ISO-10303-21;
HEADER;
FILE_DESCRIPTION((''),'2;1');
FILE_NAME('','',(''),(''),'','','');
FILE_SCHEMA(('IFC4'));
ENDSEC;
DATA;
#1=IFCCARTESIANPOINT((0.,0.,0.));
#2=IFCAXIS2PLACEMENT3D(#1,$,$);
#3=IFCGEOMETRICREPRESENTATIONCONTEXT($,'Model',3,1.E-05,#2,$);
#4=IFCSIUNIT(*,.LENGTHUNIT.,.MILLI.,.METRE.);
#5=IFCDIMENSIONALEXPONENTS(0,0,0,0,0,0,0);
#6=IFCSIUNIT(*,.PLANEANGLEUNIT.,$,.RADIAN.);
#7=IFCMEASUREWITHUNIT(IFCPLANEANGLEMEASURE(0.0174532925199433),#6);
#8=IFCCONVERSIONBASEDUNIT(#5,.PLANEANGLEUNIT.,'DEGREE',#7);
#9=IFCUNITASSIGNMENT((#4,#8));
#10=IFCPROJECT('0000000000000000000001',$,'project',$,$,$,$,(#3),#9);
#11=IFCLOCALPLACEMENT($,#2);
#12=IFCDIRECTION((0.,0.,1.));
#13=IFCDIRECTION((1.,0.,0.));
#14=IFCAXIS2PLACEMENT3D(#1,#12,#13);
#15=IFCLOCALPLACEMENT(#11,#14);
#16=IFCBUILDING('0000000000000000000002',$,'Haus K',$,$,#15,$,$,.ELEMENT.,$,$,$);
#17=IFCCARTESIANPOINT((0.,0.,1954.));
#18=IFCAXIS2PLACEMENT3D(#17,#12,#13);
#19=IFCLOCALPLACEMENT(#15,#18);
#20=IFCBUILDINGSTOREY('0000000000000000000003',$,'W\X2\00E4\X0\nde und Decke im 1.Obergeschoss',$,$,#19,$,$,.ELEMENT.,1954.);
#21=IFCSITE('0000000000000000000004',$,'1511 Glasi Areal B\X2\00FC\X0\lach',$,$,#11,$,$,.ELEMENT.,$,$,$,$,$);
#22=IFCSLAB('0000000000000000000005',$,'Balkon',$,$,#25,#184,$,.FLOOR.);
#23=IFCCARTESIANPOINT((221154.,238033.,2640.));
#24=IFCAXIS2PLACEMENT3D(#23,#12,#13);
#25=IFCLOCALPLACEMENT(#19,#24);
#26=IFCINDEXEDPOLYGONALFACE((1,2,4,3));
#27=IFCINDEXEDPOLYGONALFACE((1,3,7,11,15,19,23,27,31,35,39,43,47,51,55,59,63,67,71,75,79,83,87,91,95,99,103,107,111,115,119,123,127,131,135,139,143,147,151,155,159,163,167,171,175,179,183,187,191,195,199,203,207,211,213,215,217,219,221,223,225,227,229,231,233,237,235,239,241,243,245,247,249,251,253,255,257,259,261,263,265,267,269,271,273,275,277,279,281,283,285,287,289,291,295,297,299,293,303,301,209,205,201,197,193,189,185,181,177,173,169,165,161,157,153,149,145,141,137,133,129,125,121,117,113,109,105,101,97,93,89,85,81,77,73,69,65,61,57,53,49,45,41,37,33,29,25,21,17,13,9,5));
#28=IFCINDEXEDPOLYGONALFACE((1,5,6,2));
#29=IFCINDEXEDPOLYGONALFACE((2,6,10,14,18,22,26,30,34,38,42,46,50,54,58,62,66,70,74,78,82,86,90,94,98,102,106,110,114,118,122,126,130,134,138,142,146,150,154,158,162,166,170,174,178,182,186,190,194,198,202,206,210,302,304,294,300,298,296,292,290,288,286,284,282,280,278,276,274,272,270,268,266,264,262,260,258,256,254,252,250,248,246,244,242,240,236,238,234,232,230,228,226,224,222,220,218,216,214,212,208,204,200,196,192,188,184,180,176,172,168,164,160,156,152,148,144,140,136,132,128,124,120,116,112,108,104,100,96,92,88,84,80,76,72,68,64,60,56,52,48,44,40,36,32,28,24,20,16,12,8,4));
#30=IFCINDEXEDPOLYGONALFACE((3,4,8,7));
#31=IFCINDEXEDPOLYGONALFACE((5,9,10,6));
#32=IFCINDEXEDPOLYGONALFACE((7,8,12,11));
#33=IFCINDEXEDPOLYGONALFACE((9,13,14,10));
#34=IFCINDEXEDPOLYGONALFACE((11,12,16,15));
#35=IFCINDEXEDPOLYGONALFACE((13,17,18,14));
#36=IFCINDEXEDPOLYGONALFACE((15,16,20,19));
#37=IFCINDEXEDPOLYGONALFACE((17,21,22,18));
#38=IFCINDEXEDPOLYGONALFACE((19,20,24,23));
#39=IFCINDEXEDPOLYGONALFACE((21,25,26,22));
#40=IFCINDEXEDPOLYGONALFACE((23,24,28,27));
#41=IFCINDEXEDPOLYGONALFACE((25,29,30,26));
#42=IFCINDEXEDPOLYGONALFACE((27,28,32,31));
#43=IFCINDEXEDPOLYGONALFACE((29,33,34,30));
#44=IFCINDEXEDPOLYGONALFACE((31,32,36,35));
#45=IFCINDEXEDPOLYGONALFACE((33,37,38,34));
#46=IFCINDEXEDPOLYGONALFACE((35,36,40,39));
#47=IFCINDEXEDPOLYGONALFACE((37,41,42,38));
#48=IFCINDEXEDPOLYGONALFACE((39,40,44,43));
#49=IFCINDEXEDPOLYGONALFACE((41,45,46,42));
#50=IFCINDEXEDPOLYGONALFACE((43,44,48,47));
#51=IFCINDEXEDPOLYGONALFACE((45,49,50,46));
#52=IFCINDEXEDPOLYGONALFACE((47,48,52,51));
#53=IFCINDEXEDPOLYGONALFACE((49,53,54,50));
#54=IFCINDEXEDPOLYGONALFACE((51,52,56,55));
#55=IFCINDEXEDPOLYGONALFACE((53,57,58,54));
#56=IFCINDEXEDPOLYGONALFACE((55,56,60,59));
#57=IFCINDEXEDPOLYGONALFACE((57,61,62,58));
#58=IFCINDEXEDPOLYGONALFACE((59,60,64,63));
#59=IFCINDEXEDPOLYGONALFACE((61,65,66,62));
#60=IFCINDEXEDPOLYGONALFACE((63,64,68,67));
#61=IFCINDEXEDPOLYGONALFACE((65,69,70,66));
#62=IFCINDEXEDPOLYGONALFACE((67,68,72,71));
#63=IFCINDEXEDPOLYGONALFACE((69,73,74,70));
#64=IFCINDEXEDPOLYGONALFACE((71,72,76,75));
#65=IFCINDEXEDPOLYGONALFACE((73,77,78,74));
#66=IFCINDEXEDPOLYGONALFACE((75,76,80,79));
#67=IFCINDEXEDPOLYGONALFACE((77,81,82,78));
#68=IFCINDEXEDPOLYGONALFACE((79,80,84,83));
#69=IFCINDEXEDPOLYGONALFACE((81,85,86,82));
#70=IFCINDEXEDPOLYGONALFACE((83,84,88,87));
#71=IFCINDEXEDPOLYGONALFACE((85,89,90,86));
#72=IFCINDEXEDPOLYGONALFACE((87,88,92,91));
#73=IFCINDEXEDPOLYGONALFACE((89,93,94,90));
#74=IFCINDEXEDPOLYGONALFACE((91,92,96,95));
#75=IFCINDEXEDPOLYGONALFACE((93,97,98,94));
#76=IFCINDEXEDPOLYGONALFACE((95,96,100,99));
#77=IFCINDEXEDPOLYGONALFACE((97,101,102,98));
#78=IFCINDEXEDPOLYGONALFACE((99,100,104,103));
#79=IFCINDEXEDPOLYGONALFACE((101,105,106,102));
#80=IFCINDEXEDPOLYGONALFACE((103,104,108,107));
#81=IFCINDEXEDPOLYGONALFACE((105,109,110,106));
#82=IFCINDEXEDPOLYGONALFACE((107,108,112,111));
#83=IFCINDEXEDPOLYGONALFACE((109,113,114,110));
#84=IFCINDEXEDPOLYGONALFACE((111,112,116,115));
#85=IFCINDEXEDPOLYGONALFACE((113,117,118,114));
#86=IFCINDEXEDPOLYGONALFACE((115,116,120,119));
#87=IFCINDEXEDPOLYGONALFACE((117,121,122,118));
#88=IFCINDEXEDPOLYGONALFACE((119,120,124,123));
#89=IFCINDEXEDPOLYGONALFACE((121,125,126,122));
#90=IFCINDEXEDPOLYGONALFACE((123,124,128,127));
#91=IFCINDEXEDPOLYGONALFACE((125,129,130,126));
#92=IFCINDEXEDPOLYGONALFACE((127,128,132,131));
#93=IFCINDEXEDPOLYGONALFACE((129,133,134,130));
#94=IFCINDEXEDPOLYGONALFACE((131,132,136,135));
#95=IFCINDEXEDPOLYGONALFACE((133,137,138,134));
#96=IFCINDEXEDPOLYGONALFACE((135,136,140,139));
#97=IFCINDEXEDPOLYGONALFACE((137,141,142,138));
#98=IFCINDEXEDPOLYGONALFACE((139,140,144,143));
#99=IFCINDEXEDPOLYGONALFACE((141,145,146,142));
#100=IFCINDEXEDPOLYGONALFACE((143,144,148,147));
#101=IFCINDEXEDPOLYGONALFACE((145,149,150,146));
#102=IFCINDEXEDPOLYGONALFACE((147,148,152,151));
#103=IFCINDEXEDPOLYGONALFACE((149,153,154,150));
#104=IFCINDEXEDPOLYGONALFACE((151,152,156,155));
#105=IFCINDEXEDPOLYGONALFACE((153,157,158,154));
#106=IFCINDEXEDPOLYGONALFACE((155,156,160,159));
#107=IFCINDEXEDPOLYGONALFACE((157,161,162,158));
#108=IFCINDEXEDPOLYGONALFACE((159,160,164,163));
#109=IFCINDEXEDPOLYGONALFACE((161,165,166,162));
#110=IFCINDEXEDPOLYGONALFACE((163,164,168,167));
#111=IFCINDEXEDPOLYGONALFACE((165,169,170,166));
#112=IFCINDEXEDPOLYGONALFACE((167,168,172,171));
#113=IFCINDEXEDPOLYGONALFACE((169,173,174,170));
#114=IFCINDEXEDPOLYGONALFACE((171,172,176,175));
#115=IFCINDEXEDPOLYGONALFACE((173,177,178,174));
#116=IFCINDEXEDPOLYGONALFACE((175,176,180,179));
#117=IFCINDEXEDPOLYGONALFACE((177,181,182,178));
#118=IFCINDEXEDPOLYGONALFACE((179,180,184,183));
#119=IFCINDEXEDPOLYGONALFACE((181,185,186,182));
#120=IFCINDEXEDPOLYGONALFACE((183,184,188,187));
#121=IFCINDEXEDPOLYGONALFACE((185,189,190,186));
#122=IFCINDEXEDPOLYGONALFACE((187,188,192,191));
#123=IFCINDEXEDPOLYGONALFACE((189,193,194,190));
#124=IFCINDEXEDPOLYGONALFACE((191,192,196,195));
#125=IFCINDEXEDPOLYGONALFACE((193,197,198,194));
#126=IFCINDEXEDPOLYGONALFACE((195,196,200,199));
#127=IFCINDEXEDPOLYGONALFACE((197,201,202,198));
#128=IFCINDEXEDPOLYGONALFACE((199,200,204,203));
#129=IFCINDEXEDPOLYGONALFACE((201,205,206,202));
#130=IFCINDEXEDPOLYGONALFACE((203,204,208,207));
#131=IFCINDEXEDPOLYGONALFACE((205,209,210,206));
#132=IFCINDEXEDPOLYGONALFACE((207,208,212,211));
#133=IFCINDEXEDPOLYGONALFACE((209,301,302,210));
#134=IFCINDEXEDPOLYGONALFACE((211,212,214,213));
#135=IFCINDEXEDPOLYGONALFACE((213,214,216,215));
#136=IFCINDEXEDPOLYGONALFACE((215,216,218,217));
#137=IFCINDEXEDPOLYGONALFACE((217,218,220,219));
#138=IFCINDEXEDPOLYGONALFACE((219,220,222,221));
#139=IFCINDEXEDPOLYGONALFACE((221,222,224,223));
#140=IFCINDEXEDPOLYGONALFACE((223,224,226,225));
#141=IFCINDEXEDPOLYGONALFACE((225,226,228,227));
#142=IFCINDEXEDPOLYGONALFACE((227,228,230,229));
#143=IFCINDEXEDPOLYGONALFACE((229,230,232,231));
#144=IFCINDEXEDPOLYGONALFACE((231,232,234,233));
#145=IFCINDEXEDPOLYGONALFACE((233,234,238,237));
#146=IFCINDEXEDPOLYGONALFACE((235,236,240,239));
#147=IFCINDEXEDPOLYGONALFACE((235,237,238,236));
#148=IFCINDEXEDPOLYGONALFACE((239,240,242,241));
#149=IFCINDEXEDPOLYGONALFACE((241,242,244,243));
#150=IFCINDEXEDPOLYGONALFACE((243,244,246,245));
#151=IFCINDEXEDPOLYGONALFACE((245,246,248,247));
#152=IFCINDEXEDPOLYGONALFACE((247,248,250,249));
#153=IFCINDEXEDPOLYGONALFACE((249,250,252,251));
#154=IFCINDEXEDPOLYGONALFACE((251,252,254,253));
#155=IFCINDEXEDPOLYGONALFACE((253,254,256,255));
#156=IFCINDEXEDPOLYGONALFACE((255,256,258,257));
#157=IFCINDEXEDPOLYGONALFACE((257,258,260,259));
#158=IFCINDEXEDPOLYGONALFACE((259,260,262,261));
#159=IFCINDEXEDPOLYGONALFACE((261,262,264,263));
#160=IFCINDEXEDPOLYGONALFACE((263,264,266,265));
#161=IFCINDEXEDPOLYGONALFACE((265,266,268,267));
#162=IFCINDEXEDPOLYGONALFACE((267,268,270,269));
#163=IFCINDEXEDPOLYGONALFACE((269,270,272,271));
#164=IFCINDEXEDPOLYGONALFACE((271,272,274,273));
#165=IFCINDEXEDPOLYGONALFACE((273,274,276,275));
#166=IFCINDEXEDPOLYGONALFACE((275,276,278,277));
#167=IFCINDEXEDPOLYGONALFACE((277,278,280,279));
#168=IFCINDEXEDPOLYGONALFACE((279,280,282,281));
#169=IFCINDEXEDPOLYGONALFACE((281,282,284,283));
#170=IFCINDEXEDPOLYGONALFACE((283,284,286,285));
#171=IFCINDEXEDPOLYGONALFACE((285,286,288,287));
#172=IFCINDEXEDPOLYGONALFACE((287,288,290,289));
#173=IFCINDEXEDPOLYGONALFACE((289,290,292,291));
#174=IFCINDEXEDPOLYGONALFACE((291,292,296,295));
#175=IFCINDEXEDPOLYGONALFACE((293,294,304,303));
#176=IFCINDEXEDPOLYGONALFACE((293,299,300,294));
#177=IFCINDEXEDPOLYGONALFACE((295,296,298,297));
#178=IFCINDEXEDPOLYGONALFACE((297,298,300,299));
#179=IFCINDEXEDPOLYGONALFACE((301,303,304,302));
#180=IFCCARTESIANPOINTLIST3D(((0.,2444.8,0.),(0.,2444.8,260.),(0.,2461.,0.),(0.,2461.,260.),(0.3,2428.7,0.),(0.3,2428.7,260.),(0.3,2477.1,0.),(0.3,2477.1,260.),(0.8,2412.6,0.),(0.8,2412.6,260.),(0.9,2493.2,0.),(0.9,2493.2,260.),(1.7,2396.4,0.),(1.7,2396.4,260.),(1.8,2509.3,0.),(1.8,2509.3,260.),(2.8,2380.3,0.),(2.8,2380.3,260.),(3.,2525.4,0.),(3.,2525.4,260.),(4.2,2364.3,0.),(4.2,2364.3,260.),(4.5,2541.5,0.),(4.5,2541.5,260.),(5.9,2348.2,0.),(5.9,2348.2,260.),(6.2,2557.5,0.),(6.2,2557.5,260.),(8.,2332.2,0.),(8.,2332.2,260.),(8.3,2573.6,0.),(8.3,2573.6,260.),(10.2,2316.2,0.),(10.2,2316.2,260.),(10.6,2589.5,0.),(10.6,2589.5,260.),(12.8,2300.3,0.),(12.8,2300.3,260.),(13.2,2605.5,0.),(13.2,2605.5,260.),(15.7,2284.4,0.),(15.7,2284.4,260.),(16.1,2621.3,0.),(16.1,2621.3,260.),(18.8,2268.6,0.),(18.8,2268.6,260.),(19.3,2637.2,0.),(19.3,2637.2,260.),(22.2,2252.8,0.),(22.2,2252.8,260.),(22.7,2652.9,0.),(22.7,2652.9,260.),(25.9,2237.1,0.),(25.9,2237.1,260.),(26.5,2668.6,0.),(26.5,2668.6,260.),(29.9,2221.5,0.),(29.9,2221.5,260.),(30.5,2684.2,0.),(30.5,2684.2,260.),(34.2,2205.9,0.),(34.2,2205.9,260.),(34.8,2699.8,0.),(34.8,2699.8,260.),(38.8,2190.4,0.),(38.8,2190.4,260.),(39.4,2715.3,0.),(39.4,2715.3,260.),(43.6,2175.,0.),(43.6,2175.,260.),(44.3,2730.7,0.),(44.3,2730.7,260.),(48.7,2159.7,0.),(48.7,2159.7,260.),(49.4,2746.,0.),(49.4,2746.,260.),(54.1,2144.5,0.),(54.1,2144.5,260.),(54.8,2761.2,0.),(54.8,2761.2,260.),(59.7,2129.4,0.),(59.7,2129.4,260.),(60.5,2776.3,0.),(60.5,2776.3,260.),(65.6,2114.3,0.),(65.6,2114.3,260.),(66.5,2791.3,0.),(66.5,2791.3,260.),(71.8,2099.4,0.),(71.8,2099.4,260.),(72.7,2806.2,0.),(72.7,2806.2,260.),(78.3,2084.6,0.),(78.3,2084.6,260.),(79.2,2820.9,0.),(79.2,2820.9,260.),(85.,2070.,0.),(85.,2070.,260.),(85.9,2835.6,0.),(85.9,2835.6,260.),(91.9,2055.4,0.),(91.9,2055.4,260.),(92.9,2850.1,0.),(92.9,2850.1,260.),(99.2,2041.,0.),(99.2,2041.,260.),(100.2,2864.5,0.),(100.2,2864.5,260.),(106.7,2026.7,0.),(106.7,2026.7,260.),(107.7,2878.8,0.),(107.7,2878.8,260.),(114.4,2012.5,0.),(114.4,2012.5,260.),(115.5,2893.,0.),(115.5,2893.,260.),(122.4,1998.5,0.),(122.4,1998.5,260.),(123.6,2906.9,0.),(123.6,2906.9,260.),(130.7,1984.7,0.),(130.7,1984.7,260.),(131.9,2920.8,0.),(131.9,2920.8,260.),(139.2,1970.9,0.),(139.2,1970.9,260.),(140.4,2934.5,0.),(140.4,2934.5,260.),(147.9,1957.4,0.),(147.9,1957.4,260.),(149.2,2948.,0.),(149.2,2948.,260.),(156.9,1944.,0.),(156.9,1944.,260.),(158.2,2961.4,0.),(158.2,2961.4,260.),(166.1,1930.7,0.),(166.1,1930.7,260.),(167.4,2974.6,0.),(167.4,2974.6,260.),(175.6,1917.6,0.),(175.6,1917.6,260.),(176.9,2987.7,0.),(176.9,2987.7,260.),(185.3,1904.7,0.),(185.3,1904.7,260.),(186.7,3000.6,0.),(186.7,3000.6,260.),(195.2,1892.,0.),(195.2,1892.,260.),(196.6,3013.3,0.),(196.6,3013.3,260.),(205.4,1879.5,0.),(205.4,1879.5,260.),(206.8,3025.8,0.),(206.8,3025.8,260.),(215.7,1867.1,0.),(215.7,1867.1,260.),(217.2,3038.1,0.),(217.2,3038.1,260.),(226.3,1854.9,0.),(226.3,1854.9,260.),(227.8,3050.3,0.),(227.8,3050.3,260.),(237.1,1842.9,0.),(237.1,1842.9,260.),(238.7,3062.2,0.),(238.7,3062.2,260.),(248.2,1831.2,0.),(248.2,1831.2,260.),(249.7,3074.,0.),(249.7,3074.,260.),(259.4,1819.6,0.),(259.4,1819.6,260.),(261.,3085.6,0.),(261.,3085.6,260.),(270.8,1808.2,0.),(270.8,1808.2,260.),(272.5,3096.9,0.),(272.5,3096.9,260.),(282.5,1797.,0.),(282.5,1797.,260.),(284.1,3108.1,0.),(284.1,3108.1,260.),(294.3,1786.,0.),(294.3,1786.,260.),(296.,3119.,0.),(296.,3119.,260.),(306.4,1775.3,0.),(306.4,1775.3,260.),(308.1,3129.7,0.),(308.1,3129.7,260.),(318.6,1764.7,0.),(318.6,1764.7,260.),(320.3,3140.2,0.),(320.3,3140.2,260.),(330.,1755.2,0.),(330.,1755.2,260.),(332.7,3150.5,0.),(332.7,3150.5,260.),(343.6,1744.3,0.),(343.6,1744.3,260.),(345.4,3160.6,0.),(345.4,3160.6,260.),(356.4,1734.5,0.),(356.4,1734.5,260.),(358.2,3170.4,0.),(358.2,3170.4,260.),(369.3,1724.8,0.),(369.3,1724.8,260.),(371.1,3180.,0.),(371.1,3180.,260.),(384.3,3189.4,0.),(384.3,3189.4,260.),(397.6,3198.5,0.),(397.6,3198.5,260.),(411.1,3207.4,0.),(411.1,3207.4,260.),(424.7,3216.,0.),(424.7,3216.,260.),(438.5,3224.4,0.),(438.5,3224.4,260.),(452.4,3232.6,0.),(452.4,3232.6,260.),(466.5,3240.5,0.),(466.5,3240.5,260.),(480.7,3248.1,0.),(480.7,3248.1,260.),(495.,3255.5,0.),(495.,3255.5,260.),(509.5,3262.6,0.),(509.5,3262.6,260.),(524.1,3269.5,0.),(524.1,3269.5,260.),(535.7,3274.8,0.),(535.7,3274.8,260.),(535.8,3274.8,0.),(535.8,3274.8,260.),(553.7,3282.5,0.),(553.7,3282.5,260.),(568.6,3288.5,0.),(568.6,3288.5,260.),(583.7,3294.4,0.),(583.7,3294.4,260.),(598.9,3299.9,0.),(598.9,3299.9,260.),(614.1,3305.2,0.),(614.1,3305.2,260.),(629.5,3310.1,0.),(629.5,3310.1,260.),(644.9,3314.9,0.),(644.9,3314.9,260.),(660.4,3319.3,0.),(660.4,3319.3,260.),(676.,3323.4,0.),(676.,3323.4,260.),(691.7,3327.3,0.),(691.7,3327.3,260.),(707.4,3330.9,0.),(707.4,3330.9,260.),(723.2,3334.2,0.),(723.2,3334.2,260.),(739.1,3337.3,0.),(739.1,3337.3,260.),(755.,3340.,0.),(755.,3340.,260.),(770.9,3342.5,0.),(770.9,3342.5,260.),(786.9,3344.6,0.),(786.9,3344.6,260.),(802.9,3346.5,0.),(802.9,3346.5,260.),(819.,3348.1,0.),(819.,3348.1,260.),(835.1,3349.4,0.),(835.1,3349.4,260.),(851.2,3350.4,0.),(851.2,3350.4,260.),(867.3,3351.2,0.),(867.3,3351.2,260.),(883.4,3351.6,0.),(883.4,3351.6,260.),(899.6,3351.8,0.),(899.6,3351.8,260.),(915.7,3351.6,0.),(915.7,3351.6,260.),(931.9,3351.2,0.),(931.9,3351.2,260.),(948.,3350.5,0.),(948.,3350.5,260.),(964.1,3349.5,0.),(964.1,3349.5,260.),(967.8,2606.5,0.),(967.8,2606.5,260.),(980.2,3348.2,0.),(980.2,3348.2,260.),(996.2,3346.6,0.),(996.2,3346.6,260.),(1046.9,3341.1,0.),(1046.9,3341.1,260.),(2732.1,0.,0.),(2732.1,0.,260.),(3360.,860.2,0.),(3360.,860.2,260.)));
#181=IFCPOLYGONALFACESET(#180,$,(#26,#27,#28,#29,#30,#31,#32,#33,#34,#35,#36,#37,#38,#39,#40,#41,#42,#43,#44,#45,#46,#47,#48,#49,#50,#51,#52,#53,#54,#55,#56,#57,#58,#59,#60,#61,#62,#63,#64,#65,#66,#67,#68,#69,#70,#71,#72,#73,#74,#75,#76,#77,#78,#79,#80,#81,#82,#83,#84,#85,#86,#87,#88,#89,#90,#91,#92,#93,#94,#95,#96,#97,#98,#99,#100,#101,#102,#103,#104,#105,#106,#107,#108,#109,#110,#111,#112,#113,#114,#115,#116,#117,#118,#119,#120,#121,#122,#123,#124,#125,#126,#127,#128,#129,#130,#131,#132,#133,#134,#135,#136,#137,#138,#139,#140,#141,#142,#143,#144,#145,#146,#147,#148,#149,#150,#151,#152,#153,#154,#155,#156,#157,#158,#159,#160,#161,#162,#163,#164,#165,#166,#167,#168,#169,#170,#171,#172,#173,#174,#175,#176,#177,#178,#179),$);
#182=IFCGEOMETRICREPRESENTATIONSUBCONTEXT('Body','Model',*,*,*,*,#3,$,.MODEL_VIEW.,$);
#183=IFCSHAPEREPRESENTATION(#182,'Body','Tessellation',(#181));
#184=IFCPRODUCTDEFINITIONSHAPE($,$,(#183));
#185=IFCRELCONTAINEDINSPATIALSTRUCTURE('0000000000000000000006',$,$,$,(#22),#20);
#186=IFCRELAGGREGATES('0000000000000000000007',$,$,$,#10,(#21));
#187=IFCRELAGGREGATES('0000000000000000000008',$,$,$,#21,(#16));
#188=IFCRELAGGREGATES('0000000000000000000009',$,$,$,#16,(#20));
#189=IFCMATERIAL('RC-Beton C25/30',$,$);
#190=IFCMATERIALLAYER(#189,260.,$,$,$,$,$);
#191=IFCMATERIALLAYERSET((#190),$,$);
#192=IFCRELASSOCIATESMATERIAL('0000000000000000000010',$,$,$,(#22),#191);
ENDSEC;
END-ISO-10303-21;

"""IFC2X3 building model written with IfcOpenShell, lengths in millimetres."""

from ifc_helpers import new_model, entity, si_unit, converted_unit, frame, origin, origin_with_axes, place, context, subcontext, project, spatial, polyline, outline, extrude, material, layer, layer_set, layer_usage, element, save


model = new_model("IFC2X3")

# Units and contexts
model_context = context("Model", 3, precision=1e-05, world=origin())
body_context = subcontext(model_context, "Body", "Model", "MODEL_VIEW")
ifc_project = project(units=[si_unit("LENGTHUNIT", "METRE", prefix="MILLI"), converted_unit("PLANEANGLEUNIT", "DEGREE", entity("IfcPlaneAngleMeasure", 0.0174532925199433), si_unit("PLANEANGLEUNIT", "RADIAN"), dimensions=[0, 0, 0, 0, 0, 0, 0])], contexts=[model_context])

# Site, building, storey
site_placement = place(None, origin())
site = spatial("IfcSite", under=ifc_project, at=site_placement, Name="1511 Glasi Areal Bülach", CompositionType="ELEMENT")
building_placement = place(site_placement, origin_with_axes())
building = spatial("IfcBuilding", under=site, at=building_placement, Name="Haus K", CompositionType="ELEMENT")
storey_placement = place(building_placement, frame((0.0, 0.0, 1954.0), z_axis=(0.0, 0.0, 1.0), x_axis=(1.0, 0.0, 0.0)))
storey = spatial("IfcBuildingStorey", under=building, at=storey_placement, Name="Wände und Decke im 1.Obergeschoss", CompositionType="ELEMENT", Elevation=1954.0)

# Slab
ifc_material_1 = material(Name="RC-Beton C25/30")
ifc_layer_1 = layer(ifc_material_1, 260.0)
ifc_layer_set_1 = layer_set([ifc_layer_1])
ifc_layer_usage_1 = layer_usage(ifc_layer_set_1, "AXIS3", "POSITIVE", 0.0)
slab_1_placement = place(storey_placement, frame((221154.0, 238033.0, 2640.0), z_axis=(0.0, 0.0, 1.0), x_axis=(1.0, 0.0, 0.0)))
element("IfcSlab", 1, at=slab_1_placement, inside=storey, material=ifc_layer_usage_1, Name="Balkon", PredefinedType="FLOOR", context=body_context, shape_type="SweptSolid", body=[
    extrude(outline(polyline([(996.2, 3346.6), (980.2, 3348.2), (964.1, 3349.5), (948.0, 3350.5), (931.9, 3351.2), (915.7, 3351.6), (899.6, 3351.8), (883.4, 3351.6), (867.3, 3351.2), (851.2, 3350.4), (835.1, 3349.4), (819.0, 3348.1), (802.9, 3346.5), (786.9, 3344.6), (770.9, 3342.5), (755.0, 3340.0), (739.1, 3337.3), (723.2, 3334.2), (707.4, 3330.9), (691.7, 3327.3), (676.0, 3323.4), (660.4, 3319.3), (644.9, 3314.9), (629.5, 3310.1), (614.1, 3305.2), (598.9, 3299.9), (583.7, 3294.4), (568.6, 3288.5), (553.7, 3282.5), (535.7, 3274.8), (535.8, 3274.8), (524.1, 3269.5), (509.5, 3262.6), (495.0, 3255.5), (480.7, 3248.1), (466.5, 3240.5), (452.4, 3232.6), (438.5, 3224.4), (424.7, 3216.0), (411.1, 3207.4), (397.6, 3198.5), (384.3, 3189.4), (371.1, 3180.0), (358.2, 3170.4), (345.4, 3160.6), (332.7, 3150.5), (320.3, 3140.2), (308.1, 3129.7), (296.0, 3119.0), (284.1, 3108.1), (272.5, 3096.9), (261.0, 3085.6), (249.7, 3074.0), (238.7, 3062.2), (227.8, 3050.3), (217.2, 3038.1), (206.8, 3025.8), (196.6, 3013.3), (186.7, 3000.6), (176.9, 2987.7), (167.4, 2974.6), (158.2, 2961.4), (149.2, 2948.0), (140.4, 2934.5), (131.9, 2920.8), (123.6, 2906.9), (115.5, 2893.0), (107.7, 2878.8), (100.2, 2864.5), (92.9, 2850.1), (85.9, 2835.6), (79.2, 2820.9), (72.7, 2806.2), (66.5, 2791.3), (60.5, 2776.3), (54.8, 2761.2), (49.4, 2746.0), (44.3, 2730.7), (39.4, 2715.3), (34.8, 2699.8), (30.5, 2684.2), (26.5, 2668.6), (22.7, 2652.9), (19.3, 2637.2), (16.1, 2621.3), (13.2, 2605.5), (10.6, 2589.5), (8.3, 2573.6), (6.2, 2557.5), (4.5, 2541.5), (3.0, 2525.4), (1.8, 2509.3), (0.9, 2493.2), (0.3, 2477.1), (0.0, 2461.0), (0.0, 2444.8), (0.3, 2428.7), (0.8, 2412.6), (1.7, 2396.4), (2.8, 2380.3), (4.2, 2364.3), (5.9, 2348.2), (8.0, 2332.2), (10.2, 2316.2), (12.8, 2300.3), (15.7, 2284.4), (18.8, 2268.6), (22.2, 2252.8), (25.9, 2237.1), (29.9, 2221.5), (34.2, 2205.9), (38.8, 2190.4), (43.6, 2175.0), (48.7, 2159.7), (54.1, 2144.5), (59.7, 2129.4), (65.6, 2114.3), (71.8, 2099.4), (78.3, 2084.6), (85.0, 2070.0), (91.9, 2055.4), (99.2, 2041.0), (106.7, 2026.7), (114.4, 2012.5), (122.4, 1998.5), (130.7, 1984.7), (139.2, 1970.9), (147.9, 1957.4), (156.9, 1944.0), (166.1, 1930.7), (175.6, 1917.6), (185.3, 1904.7), (195.2, 1892.0), (205.4, 1879.5), (215.7, 1867.1), (226.3, 1854.9), (237.1, 1842.9), (248.2, 1831.2), (259.4, 1819.6), (270.8, 1808.2), (282.5, 1797.0), (294.3, 1786.0), (306.4, 1775.3), (318.6, 1764.7), (330.0, 1755.2), (330.0, 1755.2), (343.6, 1744.3), (356.4, 1734.5), (369.3, 1724.8), (2732.1, 0.0), (3360.0, 860.2), (967.8, 2606.5), (1046.9, 3341.1), (996.2, 3346.6)])), origin_with_axes(), (0.0, 0.0, 1.0), 260.0),
])

save(model, "model.ifc")
